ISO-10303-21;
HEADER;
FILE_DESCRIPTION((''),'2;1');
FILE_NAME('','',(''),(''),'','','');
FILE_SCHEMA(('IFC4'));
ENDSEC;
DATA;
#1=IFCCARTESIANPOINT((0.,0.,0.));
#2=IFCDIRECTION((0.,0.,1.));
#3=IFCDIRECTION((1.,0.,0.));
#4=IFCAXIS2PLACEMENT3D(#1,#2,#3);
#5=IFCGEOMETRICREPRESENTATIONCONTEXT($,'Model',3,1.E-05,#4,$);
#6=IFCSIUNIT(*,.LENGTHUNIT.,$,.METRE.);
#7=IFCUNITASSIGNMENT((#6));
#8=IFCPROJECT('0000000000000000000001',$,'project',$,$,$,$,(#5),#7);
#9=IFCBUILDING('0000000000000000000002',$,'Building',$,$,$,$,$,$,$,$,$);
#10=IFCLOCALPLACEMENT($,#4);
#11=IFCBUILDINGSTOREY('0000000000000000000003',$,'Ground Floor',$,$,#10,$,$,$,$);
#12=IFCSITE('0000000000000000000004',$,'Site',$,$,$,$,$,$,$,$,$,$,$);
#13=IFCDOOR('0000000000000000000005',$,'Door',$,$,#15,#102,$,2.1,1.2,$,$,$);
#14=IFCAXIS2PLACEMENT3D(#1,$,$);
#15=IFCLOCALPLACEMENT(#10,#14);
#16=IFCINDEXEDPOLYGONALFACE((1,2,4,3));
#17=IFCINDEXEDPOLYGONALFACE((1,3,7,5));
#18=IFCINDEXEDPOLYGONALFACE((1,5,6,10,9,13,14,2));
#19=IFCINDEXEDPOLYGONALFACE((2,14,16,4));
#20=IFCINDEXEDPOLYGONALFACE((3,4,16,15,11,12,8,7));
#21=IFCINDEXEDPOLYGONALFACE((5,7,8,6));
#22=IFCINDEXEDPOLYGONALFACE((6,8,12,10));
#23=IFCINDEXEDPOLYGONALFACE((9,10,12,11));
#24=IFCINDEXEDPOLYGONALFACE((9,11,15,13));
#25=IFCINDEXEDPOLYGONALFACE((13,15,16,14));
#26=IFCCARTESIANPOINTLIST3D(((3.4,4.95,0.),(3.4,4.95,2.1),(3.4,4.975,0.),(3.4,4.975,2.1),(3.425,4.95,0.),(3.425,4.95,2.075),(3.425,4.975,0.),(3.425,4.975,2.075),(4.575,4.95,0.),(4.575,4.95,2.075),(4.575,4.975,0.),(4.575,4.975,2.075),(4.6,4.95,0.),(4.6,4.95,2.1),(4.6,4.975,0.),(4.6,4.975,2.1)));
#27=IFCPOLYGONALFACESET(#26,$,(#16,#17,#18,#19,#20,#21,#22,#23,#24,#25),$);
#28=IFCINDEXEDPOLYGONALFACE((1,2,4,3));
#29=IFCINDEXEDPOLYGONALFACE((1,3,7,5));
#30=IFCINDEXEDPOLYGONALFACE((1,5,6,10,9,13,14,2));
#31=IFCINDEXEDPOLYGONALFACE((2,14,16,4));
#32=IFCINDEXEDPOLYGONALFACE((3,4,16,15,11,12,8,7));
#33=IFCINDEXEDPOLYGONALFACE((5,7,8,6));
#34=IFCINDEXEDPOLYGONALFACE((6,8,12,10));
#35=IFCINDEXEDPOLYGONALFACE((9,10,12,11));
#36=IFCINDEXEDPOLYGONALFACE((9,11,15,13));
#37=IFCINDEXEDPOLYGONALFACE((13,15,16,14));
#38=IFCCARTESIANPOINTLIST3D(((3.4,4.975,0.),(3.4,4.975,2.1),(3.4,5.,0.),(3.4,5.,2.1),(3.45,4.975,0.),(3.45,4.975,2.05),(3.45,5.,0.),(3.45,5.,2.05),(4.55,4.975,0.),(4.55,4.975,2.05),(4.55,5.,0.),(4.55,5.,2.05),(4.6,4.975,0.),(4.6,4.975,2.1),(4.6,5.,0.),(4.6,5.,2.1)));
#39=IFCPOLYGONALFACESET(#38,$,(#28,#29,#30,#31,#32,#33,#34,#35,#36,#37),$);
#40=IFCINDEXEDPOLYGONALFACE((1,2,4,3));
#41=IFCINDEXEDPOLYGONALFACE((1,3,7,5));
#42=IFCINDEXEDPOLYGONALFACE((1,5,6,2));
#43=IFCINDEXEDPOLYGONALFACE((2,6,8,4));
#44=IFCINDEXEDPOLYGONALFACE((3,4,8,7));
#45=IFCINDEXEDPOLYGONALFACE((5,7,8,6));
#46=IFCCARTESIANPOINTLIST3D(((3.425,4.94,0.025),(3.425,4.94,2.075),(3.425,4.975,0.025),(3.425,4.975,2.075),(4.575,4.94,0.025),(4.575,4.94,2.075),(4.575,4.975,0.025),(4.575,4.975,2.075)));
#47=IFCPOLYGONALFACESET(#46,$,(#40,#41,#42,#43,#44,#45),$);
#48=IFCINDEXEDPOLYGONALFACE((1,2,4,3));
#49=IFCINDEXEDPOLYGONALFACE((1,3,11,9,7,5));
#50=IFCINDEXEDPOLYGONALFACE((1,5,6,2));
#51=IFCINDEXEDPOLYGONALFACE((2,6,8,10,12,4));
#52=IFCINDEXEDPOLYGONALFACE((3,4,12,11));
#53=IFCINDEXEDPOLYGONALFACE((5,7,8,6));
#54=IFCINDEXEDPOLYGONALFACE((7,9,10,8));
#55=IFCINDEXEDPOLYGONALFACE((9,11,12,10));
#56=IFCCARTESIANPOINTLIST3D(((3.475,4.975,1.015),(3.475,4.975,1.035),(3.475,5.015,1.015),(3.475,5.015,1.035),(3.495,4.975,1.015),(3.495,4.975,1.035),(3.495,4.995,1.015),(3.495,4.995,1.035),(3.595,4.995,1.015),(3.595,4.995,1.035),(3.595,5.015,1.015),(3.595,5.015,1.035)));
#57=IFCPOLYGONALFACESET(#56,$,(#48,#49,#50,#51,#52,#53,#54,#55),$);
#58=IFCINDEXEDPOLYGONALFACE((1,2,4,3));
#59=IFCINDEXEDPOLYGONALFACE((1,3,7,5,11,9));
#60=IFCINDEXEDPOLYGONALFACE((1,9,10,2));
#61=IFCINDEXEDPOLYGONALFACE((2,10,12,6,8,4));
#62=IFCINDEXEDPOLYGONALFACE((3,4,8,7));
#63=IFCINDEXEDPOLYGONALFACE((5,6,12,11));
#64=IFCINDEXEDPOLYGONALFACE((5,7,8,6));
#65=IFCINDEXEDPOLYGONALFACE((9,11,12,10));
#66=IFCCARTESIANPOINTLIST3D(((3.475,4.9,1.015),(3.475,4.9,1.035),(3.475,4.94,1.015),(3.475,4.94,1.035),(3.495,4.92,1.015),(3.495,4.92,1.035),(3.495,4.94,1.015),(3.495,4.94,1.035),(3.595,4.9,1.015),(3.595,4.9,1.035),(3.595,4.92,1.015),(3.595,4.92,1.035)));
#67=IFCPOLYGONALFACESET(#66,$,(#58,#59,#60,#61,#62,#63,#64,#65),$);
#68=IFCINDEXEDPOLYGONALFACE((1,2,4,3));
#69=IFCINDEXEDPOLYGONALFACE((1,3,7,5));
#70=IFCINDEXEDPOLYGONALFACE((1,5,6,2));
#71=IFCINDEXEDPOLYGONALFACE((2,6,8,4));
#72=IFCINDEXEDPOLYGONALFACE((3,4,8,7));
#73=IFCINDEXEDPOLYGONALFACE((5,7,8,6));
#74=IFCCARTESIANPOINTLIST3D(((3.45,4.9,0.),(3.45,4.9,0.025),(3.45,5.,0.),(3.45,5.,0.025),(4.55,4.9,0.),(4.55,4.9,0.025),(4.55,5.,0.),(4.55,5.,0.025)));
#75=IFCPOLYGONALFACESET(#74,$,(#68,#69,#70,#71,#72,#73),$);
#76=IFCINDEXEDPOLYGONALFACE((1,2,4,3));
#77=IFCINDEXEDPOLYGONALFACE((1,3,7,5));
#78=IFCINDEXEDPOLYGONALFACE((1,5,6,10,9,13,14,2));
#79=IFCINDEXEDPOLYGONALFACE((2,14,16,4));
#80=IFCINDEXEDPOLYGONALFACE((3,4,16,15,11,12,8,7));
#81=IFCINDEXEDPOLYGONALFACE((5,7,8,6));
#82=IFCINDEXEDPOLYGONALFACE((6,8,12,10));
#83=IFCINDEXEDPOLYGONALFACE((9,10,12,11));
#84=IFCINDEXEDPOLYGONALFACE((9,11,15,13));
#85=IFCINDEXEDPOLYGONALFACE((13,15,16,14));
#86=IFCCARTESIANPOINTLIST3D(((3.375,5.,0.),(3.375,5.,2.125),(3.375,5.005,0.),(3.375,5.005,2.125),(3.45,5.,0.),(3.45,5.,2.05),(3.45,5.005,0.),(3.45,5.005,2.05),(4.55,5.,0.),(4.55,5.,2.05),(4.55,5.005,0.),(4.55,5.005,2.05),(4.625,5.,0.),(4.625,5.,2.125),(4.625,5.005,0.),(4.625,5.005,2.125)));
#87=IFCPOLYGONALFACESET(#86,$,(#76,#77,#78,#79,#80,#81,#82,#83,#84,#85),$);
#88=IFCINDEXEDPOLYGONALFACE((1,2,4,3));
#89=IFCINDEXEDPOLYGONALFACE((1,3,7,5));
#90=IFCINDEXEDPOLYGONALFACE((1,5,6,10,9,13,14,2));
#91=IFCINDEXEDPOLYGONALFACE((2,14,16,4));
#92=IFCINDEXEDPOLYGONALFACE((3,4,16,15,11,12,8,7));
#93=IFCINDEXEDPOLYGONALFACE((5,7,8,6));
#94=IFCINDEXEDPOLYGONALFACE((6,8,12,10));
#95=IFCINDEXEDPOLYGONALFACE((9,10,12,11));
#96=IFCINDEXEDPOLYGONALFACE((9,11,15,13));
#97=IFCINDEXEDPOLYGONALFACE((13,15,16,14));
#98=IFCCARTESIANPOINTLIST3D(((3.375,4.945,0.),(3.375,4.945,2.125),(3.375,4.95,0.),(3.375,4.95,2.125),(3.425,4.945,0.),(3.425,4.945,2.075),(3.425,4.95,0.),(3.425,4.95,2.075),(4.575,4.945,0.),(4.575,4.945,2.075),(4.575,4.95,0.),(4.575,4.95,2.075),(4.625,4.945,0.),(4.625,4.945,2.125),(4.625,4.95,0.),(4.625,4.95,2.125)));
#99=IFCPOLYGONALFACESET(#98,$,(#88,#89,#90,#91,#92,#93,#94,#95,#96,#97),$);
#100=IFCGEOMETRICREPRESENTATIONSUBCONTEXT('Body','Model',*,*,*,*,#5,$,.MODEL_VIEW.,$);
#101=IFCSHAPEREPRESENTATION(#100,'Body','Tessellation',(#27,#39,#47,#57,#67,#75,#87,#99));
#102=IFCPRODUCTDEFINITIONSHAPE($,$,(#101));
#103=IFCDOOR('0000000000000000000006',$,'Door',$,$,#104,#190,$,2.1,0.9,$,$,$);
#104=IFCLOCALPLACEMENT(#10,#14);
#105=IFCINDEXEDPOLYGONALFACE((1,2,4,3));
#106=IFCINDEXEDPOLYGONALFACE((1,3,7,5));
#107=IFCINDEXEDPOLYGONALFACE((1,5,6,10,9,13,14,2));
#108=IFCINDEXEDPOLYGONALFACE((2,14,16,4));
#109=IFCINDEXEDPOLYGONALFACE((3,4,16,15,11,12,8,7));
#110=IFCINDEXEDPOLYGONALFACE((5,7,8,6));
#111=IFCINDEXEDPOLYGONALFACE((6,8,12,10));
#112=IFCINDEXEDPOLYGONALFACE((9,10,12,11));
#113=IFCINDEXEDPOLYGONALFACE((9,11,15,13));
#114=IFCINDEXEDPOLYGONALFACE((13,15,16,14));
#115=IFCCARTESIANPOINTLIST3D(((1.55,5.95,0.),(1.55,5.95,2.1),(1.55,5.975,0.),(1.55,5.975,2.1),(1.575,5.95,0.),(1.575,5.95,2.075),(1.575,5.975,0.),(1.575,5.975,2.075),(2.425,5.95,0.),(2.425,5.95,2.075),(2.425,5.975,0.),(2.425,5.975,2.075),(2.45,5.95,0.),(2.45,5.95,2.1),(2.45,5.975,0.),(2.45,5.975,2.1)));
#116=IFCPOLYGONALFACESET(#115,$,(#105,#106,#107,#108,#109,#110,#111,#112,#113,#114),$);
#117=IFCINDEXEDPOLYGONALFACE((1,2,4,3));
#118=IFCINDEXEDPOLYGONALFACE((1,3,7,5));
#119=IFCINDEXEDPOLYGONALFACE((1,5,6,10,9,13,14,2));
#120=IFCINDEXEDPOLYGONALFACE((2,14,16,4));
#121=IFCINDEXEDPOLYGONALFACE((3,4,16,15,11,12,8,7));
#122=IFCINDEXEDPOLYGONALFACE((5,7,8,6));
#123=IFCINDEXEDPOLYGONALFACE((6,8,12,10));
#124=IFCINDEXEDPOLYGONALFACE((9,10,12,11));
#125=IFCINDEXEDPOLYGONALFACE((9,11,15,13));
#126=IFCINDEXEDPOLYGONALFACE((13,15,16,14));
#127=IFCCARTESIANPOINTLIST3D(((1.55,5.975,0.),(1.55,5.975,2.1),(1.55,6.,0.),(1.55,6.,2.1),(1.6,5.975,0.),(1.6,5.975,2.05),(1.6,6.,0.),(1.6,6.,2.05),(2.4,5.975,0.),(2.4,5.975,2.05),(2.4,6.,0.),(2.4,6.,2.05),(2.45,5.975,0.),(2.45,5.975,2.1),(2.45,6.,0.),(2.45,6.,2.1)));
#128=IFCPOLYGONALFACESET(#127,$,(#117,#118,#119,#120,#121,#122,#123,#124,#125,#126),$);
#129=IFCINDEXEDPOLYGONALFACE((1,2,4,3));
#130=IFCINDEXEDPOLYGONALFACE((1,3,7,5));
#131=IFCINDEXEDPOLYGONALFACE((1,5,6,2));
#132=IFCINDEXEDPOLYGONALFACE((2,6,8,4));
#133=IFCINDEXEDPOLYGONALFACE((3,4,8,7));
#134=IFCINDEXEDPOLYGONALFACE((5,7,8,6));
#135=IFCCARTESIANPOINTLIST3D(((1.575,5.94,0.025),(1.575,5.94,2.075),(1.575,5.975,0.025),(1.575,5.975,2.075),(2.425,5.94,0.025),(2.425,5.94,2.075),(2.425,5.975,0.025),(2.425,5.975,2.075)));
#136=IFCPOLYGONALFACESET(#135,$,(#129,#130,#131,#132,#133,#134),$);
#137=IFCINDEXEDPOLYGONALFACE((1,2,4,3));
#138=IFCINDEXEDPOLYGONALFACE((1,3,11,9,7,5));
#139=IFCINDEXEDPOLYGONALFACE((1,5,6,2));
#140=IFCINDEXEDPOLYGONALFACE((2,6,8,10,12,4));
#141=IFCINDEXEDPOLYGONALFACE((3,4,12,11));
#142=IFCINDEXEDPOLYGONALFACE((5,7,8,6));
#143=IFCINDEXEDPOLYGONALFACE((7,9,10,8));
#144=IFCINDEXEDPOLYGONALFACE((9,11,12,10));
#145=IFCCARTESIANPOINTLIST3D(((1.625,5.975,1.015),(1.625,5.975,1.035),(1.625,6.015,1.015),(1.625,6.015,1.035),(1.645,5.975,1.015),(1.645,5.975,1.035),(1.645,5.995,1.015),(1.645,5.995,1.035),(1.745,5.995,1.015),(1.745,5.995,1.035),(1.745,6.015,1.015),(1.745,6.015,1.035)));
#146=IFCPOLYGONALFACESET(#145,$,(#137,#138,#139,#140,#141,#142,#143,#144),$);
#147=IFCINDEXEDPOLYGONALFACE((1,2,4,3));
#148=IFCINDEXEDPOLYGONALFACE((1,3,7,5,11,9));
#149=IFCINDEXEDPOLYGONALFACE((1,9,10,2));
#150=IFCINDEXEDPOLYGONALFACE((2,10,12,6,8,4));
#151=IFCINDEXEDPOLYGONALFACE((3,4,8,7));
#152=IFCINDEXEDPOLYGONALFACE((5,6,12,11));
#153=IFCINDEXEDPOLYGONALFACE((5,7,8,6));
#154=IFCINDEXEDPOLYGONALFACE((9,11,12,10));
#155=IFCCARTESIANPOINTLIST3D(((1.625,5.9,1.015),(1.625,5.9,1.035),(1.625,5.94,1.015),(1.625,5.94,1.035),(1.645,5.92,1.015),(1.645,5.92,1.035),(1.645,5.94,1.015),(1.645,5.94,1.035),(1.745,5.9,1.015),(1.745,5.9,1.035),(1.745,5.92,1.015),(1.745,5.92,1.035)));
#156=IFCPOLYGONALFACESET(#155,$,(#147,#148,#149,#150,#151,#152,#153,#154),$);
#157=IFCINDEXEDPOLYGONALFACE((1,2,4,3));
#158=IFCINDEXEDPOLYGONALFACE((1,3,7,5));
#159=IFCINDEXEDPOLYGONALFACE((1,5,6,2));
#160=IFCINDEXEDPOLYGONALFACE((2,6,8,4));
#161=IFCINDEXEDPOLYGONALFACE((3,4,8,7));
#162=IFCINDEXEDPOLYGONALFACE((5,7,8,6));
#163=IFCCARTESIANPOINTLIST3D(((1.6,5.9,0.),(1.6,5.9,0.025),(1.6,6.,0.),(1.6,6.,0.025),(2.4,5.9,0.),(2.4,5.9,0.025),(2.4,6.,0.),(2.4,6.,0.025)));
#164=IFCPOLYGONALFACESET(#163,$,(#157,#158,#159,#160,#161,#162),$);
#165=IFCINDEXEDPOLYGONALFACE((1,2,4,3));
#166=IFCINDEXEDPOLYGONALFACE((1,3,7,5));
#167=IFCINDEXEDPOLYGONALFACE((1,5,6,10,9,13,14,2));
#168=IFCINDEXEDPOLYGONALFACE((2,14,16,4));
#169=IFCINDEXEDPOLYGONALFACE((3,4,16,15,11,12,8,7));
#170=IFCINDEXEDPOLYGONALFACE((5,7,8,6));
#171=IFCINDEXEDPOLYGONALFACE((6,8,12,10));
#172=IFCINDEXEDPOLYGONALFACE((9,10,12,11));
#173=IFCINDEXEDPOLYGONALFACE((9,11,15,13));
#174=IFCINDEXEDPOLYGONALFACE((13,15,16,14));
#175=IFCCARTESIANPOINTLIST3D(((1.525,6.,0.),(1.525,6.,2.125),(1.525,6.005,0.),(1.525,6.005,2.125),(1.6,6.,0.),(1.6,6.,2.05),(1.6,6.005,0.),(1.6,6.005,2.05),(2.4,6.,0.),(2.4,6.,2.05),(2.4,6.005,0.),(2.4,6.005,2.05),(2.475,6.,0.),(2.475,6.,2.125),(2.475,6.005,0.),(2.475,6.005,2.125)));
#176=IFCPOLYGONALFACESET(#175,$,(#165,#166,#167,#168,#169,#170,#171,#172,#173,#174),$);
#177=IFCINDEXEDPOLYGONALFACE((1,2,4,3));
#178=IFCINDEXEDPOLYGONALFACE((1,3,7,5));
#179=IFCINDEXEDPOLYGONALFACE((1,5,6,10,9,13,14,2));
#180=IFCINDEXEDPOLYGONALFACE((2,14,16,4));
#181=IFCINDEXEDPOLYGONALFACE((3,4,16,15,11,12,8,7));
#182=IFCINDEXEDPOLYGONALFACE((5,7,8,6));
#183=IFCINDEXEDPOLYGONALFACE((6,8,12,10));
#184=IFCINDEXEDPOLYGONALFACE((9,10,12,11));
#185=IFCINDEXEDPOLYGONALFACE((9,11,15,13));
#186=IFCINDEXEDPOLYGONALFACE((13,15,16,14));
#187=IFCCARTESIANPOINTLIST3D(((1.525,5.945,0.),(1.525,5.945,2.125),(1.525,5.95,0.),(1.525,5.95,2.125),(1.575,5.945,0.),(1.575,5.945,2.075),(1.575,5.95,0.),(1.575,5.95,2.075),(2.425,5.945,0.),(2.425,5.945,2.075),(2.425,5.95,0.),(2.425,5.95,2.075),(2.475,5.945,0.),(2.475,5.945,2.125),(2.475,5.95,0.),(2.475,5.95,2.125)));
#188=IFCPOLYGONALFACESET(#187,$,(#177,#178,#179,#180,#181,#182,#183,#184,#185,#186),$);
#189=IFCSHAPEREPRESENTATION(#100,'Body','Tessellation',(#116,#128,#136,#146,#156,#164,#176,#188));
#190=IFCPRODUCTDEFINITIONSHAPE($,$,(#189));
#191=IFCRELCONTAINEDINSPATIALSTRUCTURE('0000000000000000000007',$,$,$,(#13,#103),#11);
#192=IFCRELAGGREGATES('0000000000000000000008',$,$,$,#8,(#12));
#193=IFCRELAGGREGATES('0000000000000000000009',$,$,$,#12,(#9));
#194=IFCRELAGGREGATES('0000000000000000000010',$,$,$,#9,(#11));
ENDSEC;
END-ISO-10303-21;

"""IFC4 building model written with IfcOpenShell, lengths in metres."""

from ifc_helpers import new_model, si_unit, frame, origin_with_axes, place, context, subcontext, project, spatial, line, indexed_curve, outline, extrude, element, save


model = new_model("IFC4")

# Units and contexts
model_context = context("Model", 3, precision=1e-05, world=origin_with_axes())
body_context = subcontext(model_context, "Body", "Model", "MODEL_VIEW")
ifc_project = project(units=[si_unit("LENGTHUNIT", "METRE")], contexts=[model_context])

# Site, building, storey
site = spatial("IfcSite", under=ifc_project, Name="Site")
building = spatial("IfcBuilding", under=site, Name="Building")
storey_placement = place(None, origin_with_axes())
storey = spatial("IfcBuildingStorey", under=building, at=storey_placement, Name="Ground Floor")

# Doors
door_1_placement = place(storey_placement, frame((4.6, 5.0, 0.0), z_axis=(0.0, 0.0, 1.0), x_axis=(-1.0, 0.0, 0.0)))
element("IfcDoor", 1, at=door_1_placement, inside=storey, Name="Door", OverallHeight=2.1, OverallWidth=1.2, context=body_context, shape_type="SweptSolid", body=[
    extrude(outline(indexed_curve([(0.0, 0.0), (0.0, 2.1), (1.2, 2.1), (1.2, 0.0), (1.175, 0.0), (1.175, 2.075), (0.025, 2.075), (0.025, 0.0)], segments=[line(1, 2, 3, 4, 5, 6, 7, 8, 1)])), frame((0.0, 0.025, 0.0), z_axis=(0.0, -1.0, 0.0), x_axis=(1.0, 0.0, 0.0)), (0.0, 0.0, -1.0), 0.025),
    extrude(outline(indexed_curve([(0.0, 0.0), (0.0, 2.1), (1.2, 2.1), (1.2, 0.0), (1.15, 0.0), (1.15, 2.05), (0.05, 2.05), (0.05, 0.0)], segments=[line(1, 2, 3, 4, 5, 6, 7, 8, 1)])), frame((0.0, 0.0, 0.0), z_axis=(0.0, -1.0, 0.0), x_axis=(1.0, 0.0, 0.0)), (0.0, 0.0, -1.0), 0.025),
    extrude(outline(indexed_curve([(0.0, 0.0), (1.15, 0.0), (1.15, 0.035), (0.0, 0.035)], segments=[line(1, 2, 3, 4, 1)])), frame((0.025, 0.025, 0.025), z_axis=(0.0, 0.0, 1.0), x_axis=(1.0, 0.0, 0.0)), (0.0, 0.0, 1.0), 2.05),
    extrude(outline(indexed_curve([(0.0, 0.0), (0.0, -0.04), (-0.12, -0.04), (-0.12, -0.02), (-0.02, -0.02), (-0.02, 0.0)], segments=[line(1, 2, 3, 4, 5, 6, 1)])), frame((1.125, 0.025, 1.015), z_axis=(0.0, 0.0, 1.0), x_axis=(1.0, 0.0, 0.0)), (0.0, 0.0, 1.0), 0.02),
    extrude(outline(indexed_curve([(0.0, 0.0), (0.0, 0.04), (-0.12, 0.04), (-0.12, 0.02), (-0.02, 0.02), (-0.02, 0.0)], segments=[line(1, 2, 3, 4, 5, 6, 1)])), frame((1.125, 0.06, 1.015), z_axis=(0.0, 0.0, 1.0), x_axis=(1.0, 0.0, 0.0)), (0.0, 0.0, 1.0), 0.02),
    extrude(outline(indexed_curve([(0.0, 0.0), (1.1, 0.0), (1.1, 0.1), (0.0, 0.1)], segments=[line(1, 2, 3, 4, 1)])), frame((0.05, 0.0, 0.0), z_axis=(0.0, 0.0, 1.0), x_axis=(1.0, 0.0, 0.0)), (0.0, 0.0, 1.0), 0.025),
    extrude(outline(indexed_curve([(0.0, 0.0), (0.0, 2.125), (1.25, 2.125), (1.25, 0.0), (1.175, 0.0), (1.175, 2.05), (0.075, 2.05), (0.075, 0.0)], segments=[line(1, 2, 3, 4, 5, 6, 7, 8, 1)])), frame((-0.025, -0.005, 0.0), z_axis=(0.0, -1.0, 0.0), x_axis=(1.0, 0.0, 0.0)), (0.0, 0.0, -1.0), 0.005),
    extrude(outline(indexed_curve([(0.0, 0.0), (0.0, 2.125), (1.25, 2.125), (1.25, 0.0), (1.2, 0.0), (1.2, 2.075), (0.05, 2.075), (0.05, 0.0)], segments=[line(1, 2, 3, 4, 5, 6, 7, 8, 1)])), frame((-0.025, 0.05, 0.0), z_axis=(0.0, -1.0, 0.0), x_axis=(1.0, 0.0, 0.0)), (0.0, 0.0, -1.0), 0.005),
])
door_2_placement = place(storey_placement, frame((2.45, 6.0, 0.0), z_axis=(0.0, 0.0, 1.0), x_axis=(-1.0, 0.0, 0.0)))
element("IfcDoor", 2, at=door_2_placement, inside=storey, Name="Door", OverallHeight=2.1, OverallWidth=0.9, context=body_context, shape_type="SweptSolid", body=[
    extrude(outline(indexed_curve([(0.0, 0.0), (0.0, 2.1), (0.9, 2.1), (0.9, 0.0), (0.875, 0.0), (0.875, 2.075), (0.025, 2.075), (0.025, 0.0)], segments=[line(1, 2, 3, 4, 5, 6, 7, 8, 1)])), frame((0.0, 0.025, 0.0), z_axis=(0.0, -1.0, 0.0), x_axis=(1.0, 0.0, 0.0)), (0.0, 0.0, -1.0), 0.025),
    extrude(outline(indexed_curve([(0.0, 0.0), (0.0, 2.1), (0.9, 2.1), (0.9, 0.0), (0.85, 0.0), (0.85, 2.05), (0.05, 2.05), (0.05, 0.0)], segments=[line(1, 2, 3, 4, 5, 6, 7, 8, 1)])), frame((0.0, 0.0, 0.0), z_axis=(0.0, -1.0, 0.0), x_axis=(1.0, 0.0, 0.0)), (0.0, 0.0, -1.0), 0.025),
    extrude(outline(indexed_curve([(0.0, 0.0), (0.85, 0.0), (0.85, 0.035), (0.0, 0.035)], segments=[line(1, 2, 3, 4, 1)])), frame((0.025, 0.025, 0.025), z_axis=(0.0, 0.0, 1.0), x_axis=(1.0, 0.0, 0.0)), (0.0, 0.0, 1.0), 2.05),
    extrude(outline(indexed_curve([(0.0, 0.0), (0.0, -0.04), (-0.12, -0.04), (-0.12, -0.02), (-0.02, -0.02), (-0.02, 0.0)], segments=[line(1, 2, 3, 4, 5, 6, 1)])), frame((0.825, 0.025, 1.015), z_axis=(0.0, 0.0, 1.0), x_axis=(1.0, 0.0, 0.0)), (0.0, 0.0, 1.0), 0.02),
    extrude(outline(indexed_curve([(0.0, 0.0), (0.0, 0.04), (-0.12, 0.04), (-0.12, 0.02), (-0.02, 0.02), (-0.02, 0.0)], segments=[line(1, 2, 3, 4, 5, 6, 1)])), frame((0.825, 0.06, 1.015), z_axis=(0.0, 0.0, 1.0), x_axis=(1.0, 0.0, 0.0)), (0.0, 0.0, 1.0), 0.02),
    extrude(outline(indexed_curve([(0.0, 0.0), (0.8, 0.0), (0.8, 0.1), (0.0, 0.1)], segments=[line(1, 2, 3, 4, 1)])), frame((0.05, 0.0, 0.0), z_axis=(0.0, 0.0, 1.0), x_axis=(1.0, 0.0, 0.0)), (0.0, 0.0, 1.0), 0.025),
    extrude(outline(indexed_curve([(0.0, 0.0), (0.0, 2.125), (0.95, 2.125), (0.95, 0.0), (0.875, 0.0), (0.875, 2.05), (0.075, 2.05), (0.075, 0.0)], segments=[line(1, 2, 3, 4, 5, 6, 7, 8, 1)])), frame((-0.025, -0.005, 0.0), z_axis=(0.0, -1.0, 0.0), x_axis=(1.0, 0.0, 0.0)), (0.0, 0.0, -1.0), 0.005),
    extrude(outline(indexed_curve([(0.0, 0.0), (0.0, 2.125), (0.95, 2.125), (0.95, 0.0), (0.9, 0.0), (0.9, 2.075), (0.05, 2.075), (0.05, 0.0)], segments=[line(1, 2, 3, 4, 5, 6, 7, 8, 1)])), frame((-0.025, 0.05, 0.0), z_axis=(0.0, -1.0, 0.0), x_axis=(1.0, 0.0, 0.0)), (0.0, 0.0, -1.0), 0.005),
])

save(model, "model.ifc")
